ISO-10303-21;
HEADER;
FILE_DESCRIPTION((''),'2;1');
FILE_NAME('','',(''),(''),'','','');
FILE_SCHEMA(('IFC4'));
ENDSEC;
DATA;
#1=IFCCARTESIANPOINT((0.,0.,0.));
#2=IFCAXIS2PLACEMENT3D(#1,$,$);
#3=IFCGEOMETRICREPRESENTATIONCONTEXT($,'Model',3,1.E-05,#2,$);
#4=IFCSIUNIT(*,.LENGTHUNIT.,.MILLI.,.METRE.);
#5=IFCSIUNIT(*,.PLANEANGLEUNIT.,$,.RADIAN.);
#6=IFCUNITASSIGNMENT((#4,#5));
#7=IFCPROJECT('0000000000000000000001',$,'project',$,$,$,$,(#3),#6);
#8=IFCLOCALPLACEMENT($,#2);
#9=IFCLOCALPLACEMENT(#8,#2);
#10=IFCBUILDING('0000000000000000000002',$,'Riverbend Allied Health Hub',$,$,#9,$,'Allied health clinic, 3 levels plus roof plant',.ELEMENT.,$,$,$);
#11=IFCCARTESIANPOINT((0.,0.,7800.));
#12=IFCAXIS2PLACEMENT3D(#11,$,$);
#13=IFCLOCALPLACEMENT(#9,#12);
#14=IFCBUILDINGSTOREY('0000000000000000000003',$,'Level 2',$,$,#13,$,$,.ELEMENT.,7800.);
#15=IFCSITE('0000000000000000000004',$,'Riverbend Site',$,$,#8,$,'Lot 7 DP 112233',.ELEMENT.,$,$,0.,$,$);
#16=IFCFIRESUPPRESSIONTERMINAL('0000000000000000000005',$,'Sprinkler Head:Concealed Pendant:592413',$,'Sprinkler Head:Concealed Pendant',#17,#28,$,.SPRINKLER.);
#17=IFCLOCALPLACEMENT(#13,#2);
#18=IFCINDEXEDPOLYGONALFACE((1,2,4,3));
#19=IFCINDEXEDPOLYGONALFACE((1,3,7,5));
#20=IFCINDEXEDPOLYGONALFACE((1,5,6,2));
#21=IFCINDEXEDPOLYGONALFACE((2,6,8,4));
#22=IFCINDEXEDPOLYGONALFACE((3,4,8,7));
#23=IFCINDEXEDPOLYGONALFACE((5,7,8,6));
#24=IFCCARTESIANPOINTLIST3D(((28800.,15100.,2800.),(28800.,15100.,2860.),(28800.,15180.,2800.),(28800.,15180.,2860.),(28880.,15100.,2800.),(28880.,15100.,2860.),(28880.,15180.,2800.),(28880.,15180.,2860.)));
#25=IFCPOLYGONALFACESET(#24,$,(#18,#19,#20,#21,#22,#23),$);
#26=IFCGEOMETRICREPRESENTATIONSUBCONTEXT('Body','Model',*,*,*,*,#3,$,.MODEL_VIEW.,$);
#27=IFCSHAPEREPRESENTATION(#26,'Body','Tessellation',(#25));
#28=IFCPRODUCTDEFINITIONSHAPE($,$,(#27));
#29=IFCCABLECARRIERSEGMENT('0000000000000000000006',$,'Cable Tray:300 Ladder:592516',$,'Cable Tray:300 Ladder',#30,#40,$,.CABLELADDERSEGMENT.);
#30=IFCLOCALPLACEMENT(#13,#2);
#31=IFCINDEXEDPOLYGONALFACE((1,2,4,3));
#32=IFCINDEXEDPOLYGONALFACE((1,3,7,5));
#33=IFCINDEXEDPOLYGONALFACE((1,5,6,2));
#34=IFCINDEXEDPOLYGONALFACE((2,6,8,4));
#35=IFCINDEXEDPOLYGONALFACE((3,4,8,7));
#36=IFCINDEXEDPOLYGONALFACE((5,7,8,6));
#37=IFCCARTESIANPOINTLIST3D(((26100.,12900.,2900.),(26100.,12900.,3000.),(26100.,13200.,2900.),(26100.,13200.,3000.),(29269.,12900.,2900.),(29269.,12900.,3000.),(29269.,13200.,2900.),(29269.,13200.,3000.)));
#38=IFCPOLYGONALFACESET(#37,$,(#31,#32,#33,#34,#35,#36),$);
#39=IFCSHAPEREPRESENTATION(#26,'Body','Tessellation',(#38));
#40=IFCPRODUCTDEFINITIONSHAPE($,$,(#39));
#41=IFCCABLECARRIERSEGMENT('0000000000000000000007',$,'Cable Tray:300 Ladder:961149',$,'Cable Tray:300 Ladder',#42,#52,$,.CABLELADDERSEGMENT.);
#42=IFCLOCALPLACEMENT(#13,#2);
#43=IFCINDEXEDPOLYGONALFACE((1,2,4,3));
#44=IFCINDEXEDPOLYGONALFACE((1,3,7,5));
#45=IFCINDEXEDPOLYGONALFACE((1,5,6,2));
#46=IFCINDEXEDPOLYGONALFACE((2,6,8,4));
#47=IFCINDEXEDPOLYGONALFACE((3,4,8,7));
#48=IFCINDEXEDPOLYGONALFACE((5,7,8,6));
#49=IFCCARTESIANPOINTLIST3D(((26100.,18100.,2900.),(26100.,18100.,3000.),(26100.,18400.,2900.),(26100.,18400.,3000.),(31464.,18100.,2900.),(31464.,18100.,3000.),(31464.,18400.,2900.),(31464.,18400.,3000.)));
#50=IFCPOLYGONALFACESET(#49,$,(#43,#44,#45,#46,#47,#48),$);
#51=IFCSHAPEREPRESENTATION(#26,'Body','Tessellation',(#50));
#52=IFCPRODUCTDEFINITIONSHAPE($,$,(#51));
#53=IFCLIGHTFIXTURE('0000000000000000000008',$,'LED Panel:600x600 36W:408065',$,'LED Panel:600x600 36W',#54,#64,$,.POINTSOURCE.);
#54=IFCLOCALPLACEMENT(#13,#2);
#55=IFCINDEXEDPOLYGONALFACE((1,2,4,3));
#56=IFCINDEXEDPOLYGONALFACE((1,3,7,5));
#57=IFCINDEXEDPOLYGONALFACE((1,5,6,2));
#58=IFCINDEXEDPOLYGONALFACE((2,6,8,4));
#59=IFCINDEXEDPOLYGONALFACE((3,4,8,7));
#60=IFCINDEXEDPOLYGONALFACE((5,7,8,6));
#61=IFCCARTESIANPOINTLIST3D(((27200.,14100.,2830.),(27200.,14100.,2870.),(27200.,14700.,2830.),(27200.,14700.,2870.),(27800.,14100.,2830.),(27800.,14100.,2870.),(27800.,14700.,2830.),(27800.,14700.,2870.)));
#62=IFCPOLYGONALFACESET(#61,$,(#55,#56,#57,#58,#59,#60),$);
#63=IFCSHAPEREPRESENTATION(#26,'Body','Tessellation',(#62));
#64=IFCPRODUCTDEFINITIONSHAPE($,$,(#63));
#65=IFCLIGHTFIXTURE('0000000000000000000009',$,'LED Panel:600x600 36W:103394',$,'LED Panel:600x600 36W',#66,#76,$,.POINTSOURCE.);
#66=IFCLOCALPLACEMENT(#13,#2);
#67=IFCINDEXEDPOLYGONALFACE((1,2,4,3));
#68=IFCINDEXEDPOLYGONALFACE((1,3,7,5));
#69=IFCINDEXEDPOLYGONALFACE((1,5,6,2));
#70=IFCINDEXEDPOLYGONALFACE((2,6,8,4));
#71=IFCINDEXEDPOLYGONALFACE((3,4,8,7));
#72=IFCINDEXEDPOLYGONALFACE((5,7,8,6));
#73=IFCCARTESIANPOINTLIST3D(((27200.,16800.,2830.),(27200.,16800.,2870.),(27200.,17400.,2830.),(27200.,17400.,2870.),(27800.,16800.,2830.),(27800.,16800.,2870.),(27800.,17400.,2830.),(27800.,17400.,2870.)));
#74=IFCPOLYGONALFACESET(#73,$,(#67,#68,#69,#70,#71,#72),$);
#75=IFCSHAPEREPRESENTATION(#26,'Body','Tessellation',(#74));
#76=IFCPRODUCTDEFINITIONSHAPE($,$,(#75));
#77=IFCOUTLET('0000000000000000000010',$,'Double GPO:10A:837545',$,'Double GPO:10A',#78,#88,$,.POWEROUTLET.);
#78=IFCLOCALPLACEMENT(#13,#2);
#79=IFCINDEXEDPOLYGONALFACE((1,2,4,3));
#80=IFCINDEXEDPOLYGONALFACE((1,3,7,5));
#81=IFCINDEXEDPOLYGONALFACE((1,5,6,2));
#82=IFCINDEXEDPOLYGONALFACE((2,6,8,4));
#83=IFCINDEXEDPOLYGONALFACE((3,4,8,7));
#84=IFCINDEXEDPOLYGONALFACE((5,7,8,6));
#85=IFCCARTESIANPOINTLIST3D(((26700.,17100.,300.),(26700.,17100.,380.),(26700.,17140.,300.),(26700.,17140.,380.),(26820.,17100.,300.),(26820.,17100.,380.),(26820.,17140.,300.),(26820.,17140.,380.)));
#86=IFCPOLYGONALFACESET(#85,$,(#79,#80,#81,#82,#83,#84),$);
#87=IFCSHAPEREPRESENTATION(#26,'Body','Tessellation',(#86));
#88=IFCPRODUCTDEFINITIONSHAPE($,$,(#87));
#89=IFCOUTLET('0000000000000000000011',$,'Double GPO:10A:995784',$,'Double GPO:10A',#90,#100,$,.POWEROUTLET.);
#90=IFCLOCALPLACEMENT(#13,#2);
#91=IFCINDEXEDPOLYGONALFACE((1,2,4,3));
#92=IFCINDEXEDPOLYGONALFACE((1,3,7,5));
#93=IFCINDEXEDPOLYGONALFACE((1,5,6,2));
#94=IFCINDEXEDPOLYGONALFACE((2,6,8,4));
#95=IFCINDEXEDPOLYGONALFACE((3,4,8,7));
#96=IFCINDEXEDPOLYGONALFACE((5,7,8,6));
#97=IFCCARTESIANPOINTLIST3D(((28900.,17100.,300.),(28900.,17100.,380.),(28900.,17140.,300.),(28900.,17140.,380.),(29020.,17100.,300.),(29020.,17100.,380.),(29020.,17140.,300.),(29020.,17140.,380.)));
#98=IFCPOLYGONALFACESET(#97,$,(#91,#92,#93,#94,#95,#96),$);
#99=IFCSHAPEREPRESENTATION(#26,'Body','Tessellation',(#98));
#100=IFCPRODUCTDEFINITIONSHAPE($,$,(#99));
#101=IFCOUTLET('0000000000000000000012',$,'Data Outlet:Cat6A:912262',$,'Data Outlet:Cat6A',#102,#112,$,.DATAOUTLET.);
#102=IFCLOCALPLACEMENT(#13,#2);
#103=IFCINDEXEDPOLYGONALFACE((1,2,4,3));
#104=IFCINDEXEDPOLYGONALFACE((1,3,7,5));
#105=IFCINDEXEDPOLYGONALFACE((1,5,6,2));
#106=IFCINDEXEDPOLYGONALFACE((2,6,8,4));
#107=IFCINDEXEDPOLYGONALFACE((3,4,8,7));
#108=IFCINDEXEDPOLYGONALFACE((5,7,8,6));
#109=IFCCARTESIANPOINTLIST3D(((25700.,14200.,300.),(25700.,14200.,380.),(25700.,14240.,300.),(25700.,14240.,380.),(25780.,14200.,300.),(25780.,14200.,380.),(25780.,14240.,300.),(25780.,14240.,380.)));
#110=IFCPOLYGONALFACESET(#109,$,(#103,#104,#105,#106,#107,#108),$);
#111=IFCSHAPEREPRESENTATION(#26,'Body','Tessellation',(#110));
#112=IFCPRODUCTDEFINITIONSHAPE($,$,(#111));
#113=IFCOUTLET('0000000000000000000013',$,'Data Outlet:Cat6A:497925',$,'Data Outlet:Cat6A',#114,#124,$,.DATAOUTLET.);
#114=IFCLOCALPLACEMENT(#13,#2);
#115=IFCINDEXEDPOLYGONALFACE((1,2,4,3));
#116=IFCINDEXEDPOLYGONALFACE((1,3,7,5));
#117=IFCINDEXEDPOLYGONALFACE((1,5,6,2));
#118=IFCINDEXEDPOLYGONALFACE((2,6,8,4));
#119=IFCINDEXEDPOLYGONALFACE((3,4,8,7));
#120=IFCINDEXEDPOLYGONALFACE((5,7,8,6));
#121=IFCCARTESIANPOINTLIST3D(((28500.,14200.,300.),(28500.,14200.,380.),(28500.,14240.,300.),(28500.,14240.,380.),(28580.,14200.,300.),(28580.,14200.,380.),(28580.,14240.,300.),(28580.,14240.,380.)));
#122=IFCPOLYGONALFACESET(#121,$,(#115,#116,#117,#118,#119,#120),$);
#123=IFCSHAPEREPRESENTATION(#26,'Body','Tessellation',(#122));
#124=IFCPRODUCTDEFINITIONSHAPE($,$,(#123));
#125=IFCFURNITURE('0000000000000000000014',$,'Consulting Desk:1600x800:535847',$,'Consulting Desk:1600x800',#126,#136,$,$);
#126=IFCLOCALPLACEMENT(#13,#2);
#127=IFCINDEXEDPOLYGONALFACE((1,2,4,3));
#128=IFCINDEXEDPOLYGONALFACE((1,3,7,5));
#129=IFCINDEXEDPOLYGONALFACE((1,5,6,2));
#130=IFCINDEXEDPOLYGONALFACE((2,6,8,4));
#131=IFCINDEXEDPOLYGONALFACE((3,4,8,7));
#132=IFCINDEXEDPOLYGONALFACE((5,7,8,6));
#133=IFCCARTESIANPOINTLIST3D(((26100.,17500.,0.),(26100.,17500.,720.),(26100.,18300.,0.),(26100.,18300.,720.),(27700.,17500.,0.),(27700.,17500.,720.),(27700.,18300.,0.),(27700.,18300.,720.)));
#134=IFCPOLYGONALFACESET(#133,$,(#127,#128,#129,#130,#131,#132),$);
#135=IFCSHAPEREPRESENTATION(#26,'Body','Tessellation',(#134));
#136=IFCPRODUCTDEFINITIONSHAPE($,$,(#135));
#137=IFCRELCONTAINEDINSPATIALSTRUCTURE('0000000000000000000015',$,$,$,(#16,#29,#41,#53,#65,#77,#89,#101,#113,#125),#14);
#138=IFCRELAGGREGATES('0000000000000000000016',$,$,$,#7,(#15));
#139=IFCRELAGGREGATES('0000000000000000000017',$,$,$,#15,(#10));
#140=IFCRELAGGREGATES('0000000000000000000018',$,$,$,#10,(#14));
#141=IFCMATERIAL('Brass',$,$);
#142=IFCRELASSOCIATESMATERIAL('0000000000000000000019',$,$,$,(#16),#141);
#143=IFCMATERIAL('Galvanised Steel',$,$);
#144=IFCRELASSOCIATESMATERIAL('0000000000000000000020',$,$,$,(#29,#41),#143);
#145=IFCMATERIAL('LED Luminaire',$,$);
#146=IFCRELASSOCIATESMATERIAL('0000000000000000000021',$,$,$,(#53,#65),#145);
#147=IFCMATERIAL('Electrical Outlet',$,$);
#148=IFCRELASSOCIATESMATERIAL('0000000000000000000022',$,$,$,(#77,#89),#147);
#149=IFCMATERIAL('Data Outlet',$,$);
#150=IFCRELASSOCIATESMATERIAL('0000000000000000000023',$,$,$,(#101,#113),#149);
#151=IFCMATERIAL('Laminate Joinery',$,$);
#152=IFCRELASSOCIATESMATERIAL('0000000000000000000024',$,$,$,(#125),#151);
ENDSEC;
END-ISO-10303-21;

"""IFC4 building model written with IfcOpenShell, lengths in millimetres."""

from ifc_helpers import new_model, si_unit, frame, frame_2d, origin, place, context, subcontext, project, spatial, rectangle, extrude, material, element, save


model = new_model("IFC4")

# Units and contexts
model_context = context("Model", 3, precision=1e-05, world=origin())
body_context = subcontext(model_context, "Body", "Model", "MODEL_VIEW")
ifc_project = project(units=[si_unit("LENGTHUNIT", "METRE", prefix="MILLI"), si_unit("PLANEANGLEUNIT", "RADIAN")], contexts=[model_context])

# Site, building, storey
site_placement = place(None, origin())
site = spatial("IfcSite", under=ifc_project, at=site_placement, Name="Riverbend Site", LongName="Lot 7 DP 112233", CompositionType="ELEMENT", RefElevation=0.0)
building_placement = place(site_placement, origin())
building = spatial("IfcBuilding", under=site, at=building_placement, Name="Riverbend Allied Health Hub", LongName="Allied health clinic, 3 levels plus roof plant", CompositionType="ELEMENT")
storey_placement = place(building_placement, frame((0.0, 0.0, 7800.0)))
storey = spatial("IfcBuildingStorey", under=building, at=storey_placement, Name="Level 2", CompositionType="ELEMENT", Elevation=7800.0)

# Shared definitions
ifc_material_1 = material(Name="Galvanised Steel")

# Fire suppression terminal
ifc_material_2 = material(Name="Brass")
fire_suppression_terminal_placement = place(storey_placement, frame((28800.0, 15100.0, 2800.0)))
element("IfcFireSuppressionTerminal", 1, at=fire_suppression_terminal_placement, inside=storey, material=ifc_material_2, Name="Sprinkler Head:Concealed Pendant:592413", ObjectType="Sprinkler Head:Concealed Pendant", PredefinedType="SPRINKLER", context=body_context, shape_type="SweptSolid", body=[
    extrude(rectangle(XDim=80.0, YDim=80.0, at=frame_2d((40.0, 40.0))), origin(), (0.0, 0.0, 1.0), 60.0),
])

# Cable carrier segments
cable_carrier_segment_1_placement = place(storey_placement, frame((26100.0, 12900.0, 2900.0)))
element("IfcCableCarrierSegment", 2, at=cable_carrier_segment_1_placement, inside=storey, material=ifc_material_1, Name="Cable Tray:300 Ladder:592516", ObjectType="Cable Tray:300 Ladder", PredefinedType="CABLELADDERSEGMENT", context=body_context, shape_type="SweptSolid", body=[
    extrude(rectangle(XDim=3169.0, YDim=300.0, at=frame_2d((1584.5, 150.0))), origin(), (0.0, 0.0, 1.0), 100.0),
])
cable_carrier_segment_2_placement = place(storey_placement, frame((26100.0, 18100.0, 2900.0)))
element("IfcCableCarrierSegment", 3, at=cable_carrier_segment_2_placement, inside=storey, material=ifc_material_1, Name="Cable Tray:300 Ladder:961149", ObjectType="Cable Tray:300 Ladder", PredefinedType="CABLELADDERSEGMENT", context=body_context, shape_type="SweptSolid", body=[
    extrude(rectangle(XDim=5364.0, YDim=300.0, at=frame_2d((2682.0, 150.0))), origin(), (0.0, 0.0, 1.0), 100.0),
])

# Light fixtures
ifc_material_3 = material(Name="LED Luminaire")
for number, where, name in (
    (4, (27200.0, 14100.0, 2830.0), "LED Panel:600x600 36W:408065"),
    (5, (27200.0, 16800.0, 2830.0), "LED Panel:600x600 36W:103394"),
):
    element("IfcLightFixture", number, at=place(storey_placement, frame(where)), inside=storey, material=ifc_material_3, Name=name, ObjectType="LED Panel:600x600 36W", PredefinedType="POINTSOURCE", context=body_context, shape_type="SweptSolid", body=[
        extrude(rectangle(XDim=600.0, YDim=600.0, at=frame_2d((300.0, 300.0))), origin(), (0.0, 0.0, 1.0), 40.0),
    ])

# Outlets
ifc_material_4 = material(Name="Electrical Outlet")
for number, where, name in (
    (6, (26700.0, 17100.0, 300.0), "Double GPO:10A:837545"),
    (7, (28900.0, 17100.0, 300.0), "Double GPO:10A:995784"),
):
    element("IfcOutlet", number, at=place(storey_placement, frame(where)), inside=storey, material=ifc_material_4, Name=name, ObjectType="Double GPO:10A", PredefinedType="POWEROUTLET", context=body_context, shape_type="SweptSolid", body=[
        extrude(rectangle(XDim=120.0, YDim=40.0, at=frame_2d((60.0, 20.0))), origin(), (0.0, 0.0, 1.0), 80.0),
    ])
ifc_material_5 = material(Name="Data Outlet")
for number, where, name in (
    (8, (25700.0, 14200.0, 300.0), "Data Outlet:Cat6A:912262"),
    (9, (28500.0, 14200.0, 300.0), "Data Outlet:Cat6A:497925"),
):
    element("IfcOutlet", number, at=place(storey_placement, frame(where)), inside=storey, material=ifc_material_5, Name=name, ObjectType="Data Outlet:Cat6A", PredefinedType="DATAOUTLET", context=body_context, shape_type="SweptSolid", body=[
        extrude(rectangle(XDim=80.0, YDim=40.0, at=frame_2d((40.0, 20.0))), origin(), (0.0, 0.0, 1.0), 80.0),
    ])

# Furniture
ifc_material_6 = material(Name="Laminate Joinery")
furniture_placement = place(storey_placement, frame((26100.0, 17500.0, 0.0)))
element("IfcFurniture", 10, at=furniture_placement, inside=storey, material=ifc_material_6, Name="Consulting Desk:1600x800:535847", ObjectType="Consulting Desk:1600x800", context=body_context, shape_type="SweptSolid", body=[
    extrude(rectangle(XDim=1600.0, YDim=800.0, at=frame_2d((800.0, 400.0))), origin(), (0.0, 0.0, 1.0), 720.0),
])

save(model, "model.ifc")
